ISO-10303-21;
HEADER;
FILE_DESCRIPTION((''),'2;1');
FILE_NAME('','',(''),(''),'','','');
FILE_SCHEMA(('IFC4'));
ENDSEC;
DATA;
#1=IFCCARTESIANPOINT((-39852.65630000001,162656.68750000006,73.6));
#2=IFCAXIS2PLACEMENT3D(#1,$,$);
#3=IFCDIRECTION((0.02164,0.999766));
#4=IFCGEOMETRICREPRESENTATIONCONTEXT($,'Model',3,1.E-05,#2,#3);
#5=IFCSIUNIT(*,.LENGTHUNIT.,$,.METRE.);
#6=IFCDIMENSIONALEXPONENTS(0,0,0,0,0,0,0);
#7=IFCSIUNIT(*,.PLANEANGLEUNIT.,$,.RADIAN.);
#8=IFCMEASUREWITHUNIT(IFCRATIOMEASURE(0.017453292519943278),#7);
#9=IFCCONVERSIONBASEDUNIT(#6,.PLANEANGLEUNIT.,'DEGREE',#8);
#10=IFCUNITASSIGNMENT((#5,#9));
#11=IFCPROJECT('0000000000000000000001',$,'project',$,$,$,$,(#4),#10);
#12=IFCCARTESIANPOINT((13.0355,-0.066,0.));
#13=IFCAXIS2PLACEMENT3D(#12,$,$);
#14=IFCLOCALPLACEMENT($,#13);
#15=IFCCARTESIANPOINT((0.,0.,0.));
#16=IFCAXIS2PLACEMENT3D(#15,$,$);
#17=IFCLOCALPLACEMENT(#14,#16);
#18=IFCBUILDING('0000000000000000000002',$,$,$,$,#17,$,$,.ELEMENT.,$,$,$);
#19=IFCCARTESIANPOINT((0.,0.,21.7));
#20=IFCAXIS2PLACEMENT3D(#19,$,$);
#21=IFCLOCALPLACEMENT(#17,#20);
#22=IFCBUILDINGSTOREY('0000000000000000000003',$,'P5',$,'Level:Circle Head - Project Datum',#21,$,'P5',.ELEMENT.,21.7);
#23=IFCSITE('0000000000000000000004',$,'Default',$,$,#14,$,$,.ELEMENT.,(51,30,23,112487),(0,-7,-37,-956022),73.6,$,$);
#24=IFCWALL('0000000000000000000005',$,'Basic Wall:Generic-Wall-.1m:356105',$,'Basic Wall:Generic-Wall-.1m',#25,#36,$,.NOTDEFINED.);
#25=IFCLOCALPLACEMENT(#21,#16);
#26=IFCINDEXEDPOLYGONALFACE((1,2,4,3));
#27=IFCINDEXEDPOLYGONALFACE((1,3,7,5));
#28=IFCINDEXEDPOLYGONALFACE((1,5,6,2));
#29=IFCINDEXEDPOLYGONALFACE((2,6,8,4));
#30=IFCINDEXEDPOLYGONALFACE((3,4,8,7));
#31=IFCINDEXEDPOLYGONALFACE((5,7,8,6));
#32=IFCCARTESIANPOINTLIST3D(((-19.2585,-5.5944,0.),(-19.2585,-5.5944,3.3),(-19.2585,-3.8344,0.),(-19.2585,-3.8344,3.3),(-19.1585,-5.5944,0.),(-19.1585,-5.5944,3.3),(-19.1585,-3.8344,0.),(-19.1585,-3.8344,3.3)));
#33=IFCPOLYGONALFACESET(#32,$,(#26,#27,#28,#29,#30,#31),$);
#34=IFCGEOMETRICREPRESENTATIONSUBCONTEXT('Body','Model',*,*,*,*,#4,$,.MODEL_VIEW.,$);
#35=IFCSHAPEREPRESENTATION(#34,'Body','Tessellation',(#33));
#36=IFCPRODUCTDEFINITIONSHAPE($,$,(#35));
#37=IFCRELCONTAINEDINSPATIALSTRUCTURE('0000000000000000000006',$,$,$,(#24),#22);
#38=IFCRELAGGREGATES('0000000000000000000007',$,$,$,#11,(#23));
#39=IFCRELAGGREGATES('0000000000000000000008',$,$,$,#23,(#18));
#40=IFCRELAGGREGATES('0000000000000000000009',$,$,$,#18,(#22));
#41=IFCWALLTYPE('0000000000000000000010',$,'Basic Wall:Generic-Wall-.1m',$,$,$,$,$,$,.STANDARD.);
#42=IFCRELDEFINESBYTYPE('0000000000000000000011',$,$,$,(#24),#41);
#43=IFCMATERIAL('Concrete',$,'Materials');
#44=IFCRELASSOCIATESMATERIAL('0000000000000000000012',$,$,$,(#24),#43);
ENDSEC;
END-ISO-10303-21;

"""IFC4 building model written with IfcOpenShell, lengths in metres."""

from ifc_helpers import new_model, entity, si_unit, converted_unit, direction, frame, origin, place, context, subcontext, project, spatial, indexed_curve, outline, extrude, material, type_object, element, save


model = new_model("IFC4")

# Units and contexts
model_context = context("Model", 3, precision=1e-05, world=frame((-39852.65630000001, 162656.68750000006, 73.6)), true_north=direction((0.02164, 0.999766)))
body_context = subcontext(model_context, "Body", "Model", "MODEL_VIEW")
ifc_project = project(units=[si_unit("LENGTHUNIT", "METRE"), converted_unit("PLANEANGLEUNIT", "DEGREE", entity("IfcRatioMeasure", 0.017453292519943278), si_unit("PLANEANGLEUNIT", "RADIAN"), dimensions=[0, 0, 0, 0, 0, 0, 0])], contexts=[model_context])

# Site, building, storey
site_placement = place(None, frame((13.0355, -0.066, 0.0)))
site = spatial("IfcSite", under=ifc_project, at=site_placement, Name="Default", CompositionType="ELEMENT", RefLatitude=(51, 30, 23, 112487), RefLongitude=(0, -7, -37, -956022), RefElevation=73.6)
building_placement = place(site_placement, origin())
building = spatial("IfcBuilding", under=site, at=building_placement, CompositionType="ELEMENT")
storey_placement = place(building_placement, frame((0.0, 0.0, 21.7)))
storey = spatial("IfcBuildingStorey", under=building, at=storey_placement, Name="P5", ObjectType="Level:Circle Head - Project Datum", LongName="P5", CompositionType="ELEMENT", Elevation=21.7)

# Shared definitions
ifc_material = material(Name="Concrete", Category="Materials")

# Wall
wall_type = type_object("IfcWallType", Name="Basic Wall:Generic-Wall-.1m", PredefinedType="STANDARD")
wall_1_placement = place(storey_placement, frame((-19.2085, -5.5944, 0.0), z_axis=(0.0, 0.0, 1.0), x_axis=(0.0, 1.0, 0.0)))
element("IfcWall", 1, at=wall_1_placement, inside=storey, type_object=wall_type, material=ifc_material, Name="Basic Wall:Generic-Wall-.1m:356105", ObjectType="Basic Wall:Generic-Wall-.1m", PredefinedType="NOTDEFINED", context=body_context, shape_type="SweptSolid", body=[
    extrude(outline(indexed_curve([(1.76, 0.05), (0.0, 0.05), (0.0, -0.05), (1.76, -0.05), (1.76, 0.05)], self_intersect=False)), origin(), (0.0, 0.0, 1.0), 3.3),
])

save(model, "model.ifc")
